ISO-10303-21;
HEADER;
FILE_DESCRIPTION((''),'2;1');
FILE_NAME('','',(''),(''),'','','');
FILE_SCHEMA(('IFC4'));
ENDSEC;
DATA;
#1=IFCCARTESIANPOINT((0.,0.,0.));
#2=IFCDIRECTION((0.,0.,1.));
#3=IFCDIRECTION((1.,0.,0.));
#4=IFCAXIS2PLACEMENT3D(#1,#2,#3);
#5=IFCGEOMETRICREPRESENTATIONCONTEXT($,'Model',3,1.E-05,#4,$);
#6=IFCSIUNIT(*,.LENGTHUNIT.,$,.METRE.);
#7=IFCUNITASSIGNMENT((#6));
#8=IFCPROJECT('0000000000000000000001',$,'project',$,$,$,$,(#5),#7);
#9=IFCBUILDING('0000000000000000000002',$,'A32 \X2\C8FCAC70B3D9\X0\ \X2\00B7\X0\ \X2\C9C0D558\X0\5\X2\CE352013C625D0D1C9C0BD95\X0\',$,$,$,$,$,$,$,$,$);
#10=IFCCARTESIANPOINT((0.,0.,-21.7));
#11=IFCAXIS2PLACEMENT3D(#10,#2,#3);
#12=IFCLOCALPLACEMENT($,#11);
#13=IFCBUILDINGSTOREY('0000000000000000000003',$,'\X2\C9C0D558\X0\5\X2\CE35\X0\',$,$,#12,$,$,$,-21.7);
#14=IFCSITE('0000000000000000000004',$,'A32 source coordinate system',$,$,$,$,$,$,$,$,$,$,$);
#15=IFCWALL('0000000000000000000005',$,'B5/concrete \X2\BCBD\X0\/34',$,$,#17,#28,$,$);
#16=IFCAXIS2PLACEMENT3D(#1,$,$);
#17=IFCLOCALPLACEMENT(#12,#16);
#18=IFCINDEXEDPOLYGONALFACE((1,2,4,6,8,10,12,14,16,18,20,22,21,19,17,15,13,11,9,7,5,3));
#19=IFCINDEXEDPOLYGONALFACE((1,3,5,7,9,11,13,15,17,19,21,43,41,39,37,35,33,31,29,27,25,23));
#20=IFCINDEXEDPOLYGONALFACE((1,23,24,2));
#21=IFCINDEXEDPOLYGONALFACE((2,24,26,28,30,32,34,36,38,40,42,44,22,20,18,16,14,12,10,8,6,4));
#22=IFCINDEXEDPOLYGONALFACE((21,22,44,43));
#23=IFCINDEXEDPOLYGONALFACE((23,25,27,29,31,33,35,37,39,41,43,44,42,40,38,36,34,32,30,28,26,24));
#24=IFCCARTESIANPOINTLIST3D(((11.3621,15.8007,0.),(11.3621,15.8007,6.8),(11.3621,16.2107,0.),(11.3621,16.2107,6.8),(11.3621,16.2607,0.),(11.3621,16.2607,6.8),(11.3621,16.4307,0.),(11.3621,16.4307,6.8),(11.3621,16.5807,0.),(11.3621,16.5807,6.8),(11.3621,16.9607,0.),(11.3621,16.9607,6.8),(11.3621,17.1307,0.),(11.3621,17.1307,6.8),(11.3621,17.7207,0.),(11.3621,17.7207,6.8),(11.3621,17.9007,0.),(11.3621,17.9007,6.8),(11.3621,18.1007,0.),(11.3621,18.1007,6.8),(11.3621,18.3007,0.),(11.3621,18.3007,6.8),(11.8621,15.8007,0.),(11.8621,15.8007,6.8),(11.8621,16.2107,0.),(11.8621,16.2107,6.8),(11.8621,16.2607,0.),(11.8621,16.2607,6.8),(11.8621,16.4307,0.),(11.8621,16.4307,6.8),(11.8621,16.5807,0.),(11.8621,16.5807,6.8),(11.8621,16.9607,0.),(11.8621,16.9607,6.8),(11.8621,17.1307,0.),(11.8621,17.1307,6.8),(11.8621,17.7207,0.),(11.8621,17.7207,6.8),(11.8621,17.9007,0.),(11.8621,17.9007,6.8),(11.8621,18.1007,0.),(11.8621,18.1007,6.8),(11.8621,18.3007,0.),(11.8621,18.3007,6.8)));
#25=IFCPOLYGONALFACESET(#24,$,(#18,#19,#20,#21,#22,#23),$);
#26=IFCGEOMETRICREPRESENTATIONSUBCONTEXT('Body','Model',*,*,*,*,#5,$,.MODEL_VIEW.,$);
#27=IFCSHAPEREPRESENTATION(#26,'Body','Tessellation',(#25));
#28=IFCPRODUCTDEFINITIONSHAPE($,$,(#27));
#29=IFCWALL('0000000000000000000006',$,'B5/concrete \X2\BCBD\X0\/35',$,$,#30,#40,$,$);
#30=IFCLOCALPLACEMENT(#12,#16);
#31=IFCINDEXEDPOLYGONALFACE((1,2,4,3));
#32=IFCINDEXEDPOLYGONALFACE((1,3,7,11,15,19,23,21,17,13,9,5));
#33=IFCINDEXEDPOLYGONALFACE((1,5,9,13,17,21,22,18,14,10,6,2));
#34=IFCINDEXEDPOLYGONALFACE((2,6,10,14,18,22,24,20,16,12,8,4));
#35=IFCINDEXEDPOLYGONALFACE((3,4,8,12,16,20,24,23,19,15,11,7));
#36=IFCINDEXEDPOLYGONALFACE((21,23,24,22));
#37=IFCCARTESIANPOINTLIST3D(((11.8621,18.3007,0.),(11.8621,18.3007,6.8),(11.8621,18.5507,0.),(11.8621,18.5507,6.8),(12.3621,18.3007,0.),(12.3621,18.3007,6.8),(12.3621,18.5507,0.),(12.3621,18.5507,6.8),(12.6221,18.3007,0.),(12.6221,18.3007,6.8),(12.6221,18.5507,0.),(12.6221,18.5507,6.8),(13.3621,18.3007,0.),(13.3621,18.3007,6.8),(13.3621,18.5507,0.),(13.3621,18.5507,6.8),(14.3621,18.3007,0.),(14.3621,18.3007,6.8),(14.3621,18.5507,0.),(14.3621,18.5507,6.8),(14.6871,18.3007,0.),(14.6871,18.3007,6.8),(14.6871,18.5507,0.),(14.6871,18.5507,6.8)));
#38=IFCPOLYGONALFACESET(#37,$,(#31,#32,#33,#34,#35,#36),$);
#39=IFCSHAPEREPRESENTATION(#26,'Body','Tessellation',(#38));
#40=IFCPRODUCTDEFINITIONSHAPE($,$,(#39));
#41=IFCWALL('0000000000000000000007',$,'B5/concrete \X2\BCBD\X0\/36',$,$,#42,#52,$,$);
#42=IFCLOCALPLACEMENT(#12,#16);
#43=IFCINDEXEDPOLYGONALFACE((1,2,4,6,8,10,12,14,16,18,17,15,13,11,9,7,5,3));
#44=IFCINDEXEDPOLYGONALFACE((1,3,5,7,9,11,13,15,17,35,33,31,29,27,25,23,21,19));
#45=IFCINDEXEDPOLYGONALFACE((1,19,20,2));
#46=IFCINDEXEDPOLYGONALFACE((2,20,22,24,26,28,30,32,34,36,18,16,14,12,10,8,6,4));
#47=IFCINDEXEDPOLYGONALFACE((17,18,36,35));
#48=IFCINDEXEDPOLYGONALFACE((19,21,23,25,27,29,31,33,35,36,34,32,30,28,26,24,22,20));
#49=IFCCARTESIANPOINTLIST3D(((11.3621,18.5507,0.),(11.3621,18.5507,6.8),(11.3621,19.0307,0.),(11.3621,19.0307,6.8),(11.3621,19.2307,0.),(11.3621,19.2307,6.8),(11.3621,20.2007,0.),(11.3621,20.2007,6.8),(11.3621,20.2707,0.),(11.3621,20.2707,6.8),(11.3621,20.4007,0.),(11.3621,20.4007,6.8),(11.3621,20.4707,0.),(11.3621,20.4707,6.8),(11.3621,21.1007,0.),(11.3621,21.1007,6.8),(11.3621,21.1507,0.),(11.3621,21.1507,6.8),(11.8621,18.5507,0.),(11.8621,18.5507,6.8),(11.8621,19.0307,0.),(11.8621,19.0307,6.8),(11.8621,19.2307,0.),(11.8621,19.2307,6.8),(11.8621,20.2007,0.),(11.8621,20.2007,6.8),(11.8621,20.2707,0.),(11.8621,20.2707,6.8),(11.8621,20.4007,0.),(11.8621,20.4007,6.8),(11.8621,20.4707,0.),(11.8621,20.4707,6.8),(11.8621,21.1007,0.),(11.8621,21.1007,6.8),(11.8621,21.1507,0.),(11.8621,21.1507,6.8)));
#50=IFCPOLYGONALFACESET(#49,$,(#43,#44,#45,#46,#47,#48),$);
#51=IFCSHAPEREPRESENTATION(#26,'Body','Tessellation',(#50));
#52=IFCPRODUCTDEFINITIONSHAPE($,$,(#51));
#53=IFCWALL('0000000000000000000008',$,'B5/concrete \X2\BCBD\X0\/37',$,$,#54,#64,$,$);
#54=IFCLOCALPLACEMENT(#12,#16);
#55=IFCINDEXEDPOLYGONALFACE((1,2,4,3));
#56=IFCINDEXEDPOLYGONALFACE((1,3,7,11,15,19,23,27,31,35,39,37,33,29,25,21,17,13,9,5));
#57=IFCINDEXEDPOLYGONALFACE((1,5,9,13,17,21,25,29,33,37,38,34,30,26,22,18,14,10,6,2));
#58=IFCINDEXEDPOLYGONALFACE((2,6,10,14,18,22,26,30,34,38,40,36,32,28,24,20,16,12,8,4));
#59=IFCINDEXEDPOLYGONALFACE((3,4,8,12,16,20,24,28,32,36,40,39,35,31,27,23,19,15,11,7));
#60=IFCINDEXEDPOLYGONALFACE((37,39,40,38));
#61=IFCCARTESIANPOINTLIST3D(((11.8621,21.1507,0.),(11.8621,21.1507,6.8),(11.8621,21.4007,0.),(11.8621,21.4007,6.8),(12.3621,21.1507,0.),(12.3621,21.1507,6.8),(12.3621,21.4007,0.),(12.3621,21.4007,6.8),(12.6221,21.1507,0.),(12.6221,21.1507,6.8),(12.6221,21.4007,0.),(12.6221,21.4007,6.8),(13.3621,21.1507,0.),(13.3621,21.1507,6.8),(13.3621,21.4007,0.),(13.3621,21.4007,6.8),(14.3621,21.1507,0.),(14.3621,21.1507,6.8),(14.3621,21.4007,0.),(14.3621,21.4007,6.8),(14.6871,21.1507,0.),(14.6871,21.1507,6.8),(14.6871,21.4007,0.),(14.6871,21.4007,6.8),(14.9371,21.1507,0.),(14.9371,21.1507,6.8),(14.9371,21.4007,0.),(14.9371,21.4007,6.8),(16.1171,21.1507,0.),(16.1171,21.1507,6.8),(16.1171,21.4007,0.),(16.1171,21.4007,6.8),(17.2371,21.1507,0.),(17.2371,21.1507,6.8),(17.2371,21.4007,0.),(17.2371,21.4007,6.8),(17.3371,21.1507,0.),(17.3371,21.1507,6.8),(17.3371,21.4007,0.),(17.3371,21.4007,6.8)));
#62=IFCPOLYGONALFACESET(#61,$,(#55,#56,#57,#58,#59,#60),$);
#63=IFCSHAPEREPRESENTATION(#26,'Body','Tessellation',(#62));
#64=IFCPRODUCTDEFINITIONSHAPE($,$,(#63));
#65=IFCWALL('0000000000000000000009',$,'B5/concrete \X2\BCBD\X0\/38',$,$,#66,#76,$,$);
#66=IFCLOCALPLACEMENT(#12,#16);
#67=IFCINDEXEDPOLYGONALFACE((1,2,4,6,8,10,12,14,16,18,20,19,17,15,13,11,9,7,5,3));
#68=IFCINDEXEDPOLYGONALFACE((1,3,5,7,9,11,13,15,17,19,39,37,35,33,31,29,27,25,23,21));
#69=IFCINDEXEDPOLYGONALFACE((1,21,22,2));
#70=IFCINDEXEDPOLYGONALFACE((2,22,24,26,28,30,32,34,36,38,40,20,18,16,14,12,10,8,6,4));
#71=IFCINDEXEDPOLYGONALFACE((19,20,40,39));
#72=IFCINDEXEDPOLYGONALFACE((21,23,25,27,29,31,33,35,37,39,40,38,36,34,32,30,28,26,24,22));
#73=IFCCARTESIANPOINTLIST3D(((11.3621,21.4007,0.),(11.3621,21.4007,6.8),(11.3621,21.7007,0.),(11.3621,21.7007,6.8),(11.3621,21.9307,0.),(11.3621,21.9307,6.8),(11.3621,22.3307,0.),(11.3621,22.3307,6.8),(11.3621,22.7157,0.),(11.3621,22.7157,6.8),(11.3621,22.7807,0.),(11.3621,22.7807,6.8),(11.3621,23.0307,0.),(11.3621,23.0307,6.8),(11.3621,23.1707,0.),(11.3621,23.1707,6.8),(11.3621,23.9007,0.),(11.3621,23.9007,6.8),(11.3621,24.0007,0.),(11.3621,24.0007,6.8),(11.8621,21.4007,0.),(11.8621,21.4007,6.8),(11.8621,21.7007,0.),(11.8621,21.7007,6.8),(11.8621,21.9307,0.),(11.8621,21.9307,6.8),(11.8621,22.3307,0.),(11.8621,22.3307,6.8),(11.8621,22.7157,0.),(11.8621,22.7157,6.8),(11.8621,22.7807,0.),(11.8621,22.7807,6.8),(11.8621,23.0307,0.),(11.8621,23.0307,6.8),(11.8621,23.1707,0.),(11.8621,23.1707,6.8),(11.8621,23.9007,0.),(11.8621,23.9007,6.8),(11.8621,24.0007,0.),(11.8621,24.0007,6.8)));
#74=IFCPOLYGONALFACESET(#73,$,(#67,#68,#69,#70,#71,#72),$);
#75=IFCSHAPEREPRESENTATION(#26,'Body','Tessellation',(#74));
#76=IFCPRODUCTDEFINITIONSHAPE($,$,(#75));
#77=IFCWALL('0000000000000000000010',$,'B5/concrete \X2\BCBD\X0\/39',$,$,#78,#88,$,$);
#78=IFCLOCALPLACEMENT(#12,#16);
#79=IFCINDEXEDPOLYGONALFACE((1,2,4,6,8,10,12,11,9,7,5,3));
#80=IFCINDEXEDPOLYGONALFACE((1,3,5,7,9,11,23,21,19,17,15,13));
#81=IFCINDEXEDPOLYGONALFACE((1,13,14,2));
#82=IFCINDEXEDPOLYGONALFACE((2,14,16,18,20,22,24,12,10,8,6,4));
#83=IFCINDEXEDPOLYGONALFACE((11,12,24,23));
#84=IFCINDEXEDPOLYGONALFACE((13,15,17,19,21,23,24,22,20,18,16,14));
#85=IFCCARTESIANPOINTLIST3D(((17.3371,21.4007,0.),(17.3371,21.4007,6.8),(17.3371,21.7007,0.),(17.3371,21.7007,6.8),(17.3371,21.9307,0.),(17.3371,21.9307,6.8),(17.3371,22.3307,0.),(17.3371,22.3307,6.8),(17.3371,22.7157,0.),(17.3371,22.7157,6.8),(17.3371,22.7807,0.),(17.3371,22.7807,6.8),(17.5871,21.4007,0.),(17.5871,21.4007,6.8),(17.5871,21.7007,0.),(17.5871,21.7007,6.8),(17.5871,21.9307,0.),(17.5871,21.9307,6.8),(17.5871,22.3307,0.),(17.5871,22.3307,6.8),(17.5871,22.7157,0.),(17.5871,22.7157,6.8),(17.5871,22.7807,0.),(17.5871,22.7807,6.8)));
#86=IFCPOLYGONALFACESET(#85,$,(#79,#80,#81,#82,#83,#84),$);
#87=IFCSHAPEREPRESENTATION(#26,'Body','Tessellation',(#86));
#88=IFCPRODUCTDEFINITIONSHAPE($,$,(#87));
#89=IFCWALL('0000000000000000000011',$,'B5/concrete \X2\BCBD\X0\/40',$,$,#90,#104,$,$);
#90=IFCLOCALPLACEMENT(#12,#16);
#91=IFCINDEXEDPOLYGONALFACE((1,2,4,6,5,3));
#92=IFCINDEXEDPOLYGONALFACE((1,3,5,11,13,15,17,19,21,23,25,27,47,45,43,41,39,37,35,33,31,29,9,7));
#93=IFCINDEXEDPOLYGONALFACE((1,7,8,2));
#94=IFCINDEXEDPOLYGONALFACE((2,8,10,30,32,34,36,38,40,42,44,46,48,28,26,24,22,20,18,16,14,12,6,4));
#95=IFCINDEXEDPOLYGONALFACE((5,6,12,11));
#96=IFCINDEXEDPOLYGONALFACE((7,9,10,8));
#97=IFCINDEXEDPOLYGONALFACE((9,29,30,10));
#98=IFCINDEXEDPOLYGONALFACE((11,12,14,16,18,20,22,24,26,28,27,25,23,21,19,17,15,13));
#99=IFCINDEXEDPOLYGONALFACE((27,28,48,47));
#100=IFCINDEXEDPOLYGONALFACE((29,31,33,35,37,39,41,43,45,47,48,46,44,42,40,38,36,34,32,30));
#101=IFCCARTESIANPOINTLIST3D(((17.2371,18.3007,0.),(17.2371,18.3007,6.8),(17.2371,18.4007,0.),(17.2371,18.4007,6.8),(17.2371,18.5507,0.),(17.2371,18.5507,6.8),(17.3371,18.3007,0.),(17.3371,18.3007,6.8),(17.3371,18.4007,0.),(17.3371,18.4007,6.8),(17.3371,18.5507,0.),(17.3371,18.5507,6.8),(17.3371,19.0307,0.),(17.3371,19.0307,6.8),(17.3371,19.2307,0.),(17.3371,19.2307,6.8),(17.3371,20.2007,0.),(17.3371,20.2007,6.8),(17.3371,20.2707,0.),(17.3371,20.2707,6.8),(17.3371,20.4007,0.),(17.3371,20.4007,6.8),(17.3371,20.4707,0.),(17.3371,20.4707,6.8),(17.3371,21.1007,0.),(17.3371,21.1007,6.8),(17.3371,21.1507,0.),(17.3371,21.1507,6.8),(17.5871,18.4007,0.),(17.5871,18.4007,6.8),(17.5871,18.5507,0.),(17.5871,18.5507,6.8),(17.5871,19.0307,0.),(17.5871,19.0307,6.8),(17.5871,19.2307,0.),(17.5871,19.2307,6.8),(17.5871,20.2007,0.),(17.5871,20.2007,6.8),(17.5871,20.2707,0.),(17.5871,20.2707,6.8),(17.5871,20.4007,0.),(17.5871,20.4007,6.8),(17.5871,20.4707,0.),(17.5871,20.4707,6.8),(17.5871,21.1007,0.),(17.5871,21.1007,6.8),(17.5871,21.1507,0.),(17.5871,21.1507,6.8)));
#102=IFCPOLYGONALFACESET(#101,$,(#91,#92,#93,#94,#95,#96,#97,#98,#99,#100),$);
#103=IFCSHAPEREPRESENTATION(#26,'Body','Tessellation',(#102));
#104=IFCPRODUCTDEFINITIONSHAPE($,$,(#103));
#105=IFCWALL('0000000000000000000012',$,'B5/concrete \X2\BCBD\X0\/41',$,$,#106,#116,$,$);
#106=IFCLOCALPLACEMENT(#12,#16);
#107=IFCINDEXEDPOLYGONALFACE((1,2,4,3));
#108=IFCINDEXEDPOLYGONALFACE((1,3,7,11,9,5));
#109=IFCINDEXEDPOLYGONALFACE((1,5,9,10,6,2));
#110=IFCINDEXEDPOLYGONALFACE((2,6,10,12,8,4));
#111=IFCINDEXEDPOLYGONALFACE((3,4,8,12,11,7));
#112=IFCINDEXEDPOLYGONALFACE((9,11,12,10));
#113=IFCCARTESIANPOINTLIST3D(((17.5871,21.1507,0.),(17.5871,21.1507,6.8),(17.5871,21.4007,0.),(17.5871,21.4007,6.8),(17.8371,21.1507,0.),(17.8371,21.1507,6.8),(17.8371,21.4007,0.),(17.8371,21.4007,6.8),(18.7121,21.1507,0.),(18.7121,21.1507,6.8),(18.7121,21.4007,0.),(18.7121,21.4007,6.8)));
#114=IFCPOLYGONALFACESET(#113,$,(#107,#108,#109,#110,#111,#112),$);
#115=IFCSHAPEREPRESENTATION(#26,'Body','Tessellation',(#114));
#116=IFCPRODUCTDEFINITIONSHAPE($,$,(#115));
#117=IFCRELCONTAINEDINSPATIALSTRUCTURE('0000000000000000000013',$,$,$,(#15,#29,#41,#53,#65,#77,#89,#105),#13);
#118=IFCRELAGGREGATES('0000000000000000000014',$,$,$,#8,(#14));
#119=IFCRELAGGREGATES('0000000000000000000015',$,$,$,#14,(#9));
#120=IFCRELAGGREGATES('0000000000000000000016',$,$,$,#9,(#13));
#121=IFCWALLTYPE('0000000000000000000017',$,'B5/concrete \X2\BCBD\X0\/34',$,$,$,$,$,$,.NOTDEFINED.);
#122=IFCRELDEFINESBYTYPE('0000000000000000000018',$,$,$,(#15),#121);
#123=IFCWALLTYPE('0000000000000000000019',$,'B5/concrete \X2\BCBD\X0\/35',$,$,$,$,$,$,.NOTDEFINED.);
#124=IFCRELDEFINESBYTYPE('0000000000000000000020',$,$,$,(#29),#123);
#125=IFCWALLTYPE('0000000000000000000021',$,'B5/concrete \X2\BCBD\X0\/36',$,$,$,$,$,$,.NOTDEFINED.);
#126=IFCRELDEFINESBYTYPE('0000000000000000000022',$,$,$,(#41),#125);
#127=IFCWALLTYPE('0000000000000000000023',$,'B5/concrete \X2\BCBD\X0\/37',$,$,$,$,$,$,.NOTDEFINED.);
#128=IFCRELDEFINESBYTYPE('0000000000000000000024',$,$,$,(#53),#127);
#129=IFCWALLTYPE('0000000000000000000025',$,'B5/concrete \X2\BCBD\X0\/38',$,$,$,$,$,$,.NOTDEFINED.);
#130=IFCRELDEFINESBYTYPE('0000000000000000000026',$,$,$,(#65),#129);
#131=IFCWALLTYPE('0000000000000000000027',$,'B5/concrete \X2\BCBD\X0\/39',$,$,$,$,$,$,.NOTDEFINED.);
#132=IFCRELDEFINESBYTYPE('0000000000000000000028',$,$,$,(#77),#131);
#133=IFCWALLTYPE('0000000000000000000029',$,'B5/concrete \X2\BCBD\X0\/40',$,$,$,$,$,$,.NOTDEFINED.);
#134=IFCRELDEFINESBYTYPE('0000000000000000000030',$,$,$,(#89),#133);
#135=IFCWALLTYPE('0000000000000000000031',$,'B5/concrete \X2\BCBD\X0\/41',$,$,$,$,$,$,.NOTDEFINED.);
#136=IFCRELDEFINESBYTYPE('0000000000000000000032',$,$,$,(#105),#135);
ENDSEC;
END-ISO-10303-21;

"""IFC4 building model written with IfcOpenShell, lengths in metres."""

from ifc_helpers import new_model, si_unit, frame, origin, origin_with_axes, place, context, subcontext, project, spatial, polyline, outline, extrude, source, transform, mapped, type_object, type_shapes, element, save


model = new_model("IFC4")

# Units and contexts
model_context = context("Model", 3, precision=1e-05, world=origin_with_axes())
body_context = subcontext(model_context, "Body", "Model", "MODEL_VIEW")
ifc_project = project(units=[si_unit("LENGTHUNIT", "METRE")], contexts=[model_context])

# Site, building, storey
site = spatial("IfcSite", under=ifc_project, Name="A32 source coordinate system")
building = spatial("IfcBuilding", under=site, Name="A32 주거동 · 지하5층–옥탑지붕")
storey_placement = place(None, frame((0.0, 0.0, -21.7), z_axis=(0.0, 0.0, 1.0), x_axis=(1.0, 0.0, 0.0)))
storey = spatial("IfcBuildingStorey", under=building, at=storey_placement, Name="지하5층", Elevation=-21.7)

# Walls
wall_type_1 = type_object("IfcWallType", Name="B5/concrete 벽/34", PredefinedType="NOTDEFINED")
shared_shape_1 = source(origin(), body_context, "Body", "SweptSolid", [
    extrude(outline(polyline([(11.3621, 16.2607), (11.3621, 16.4307), (11.3621, 16.5807), (11.3621, 16.9607), (11.3621, 17.1307), (11.3621, 17.7207), (11.3621, 17.9007), (11.3621, 18.1007), (11.3621, 18.3007), (11.8621, 18.3007), (11.8621, 18.1007), (11.8621, 17.9007), (11.8621, 17.7207), (11.8621, 17.1307), (11.8621, 16.9607), (11.8621, 16.5807), (11.8621, 16.4307), (11.8621, 16.2607), (11.8621, 16.2107), (11.8621, 15.8007), (11.3621, 15.8007), (11.3621, 16.2107), (11.3621, 16.2607)])), origin(), (0.0, 0.0, 1.0), 6.8),
])
type_shapes(wall_type_1, [shared_shape_1])
wall_1_placement = place(storey_placement, origin_with_axes())
element("IfcWall", 1, at=wall_1_placement, inside=storey, type_object=wall_type_1, Name="B5/concrete 벽/34", context=body_context, shape_type="MappedRepresentation", body=[
    mapped(shared_shape_1, transform((0.0, 0.0, 0.0), scale=1.0)),
])
wall_type_2 = type_object("IfcWallType", Name="B5/concrete 벽/35", PredefinedType="NOTDEFINED")
shared_shape_2 = source(origin(), body_context, "Body", "SweptSolid", [
    extrude(outline(polyline([(12.6221, 18.5507), (13.3621, 18.5507), (14.3621, 18.5507), (14.6871, 18.5507), (14.6871, 18.3007), (14.3621, 18.3007), (13.3621, 18.3007), (12.6221, 18.3007), (12.3621, 18.3007), (11.8621, 18.3007), (11.8621, 18.5507), (12.3621, 18.5507), (12.6221, 18.5507)])), origin(), (0.0, 0.0, 1.0), 6.8),
])
type_shapes(wall_type_2, [shared_shape_2])
wall_2_placement = place(storey_placement, origin_with_axes())
element("IfcWall", 2, at=wall_2_placement, inside=storey, type_object=wall_type_2, Name="B5/concrete 벽/35", context=body_context, shape_type="MappedRepresentation", body=[
    mapped(shared_shape_2, transform((0.0, 0.0, 0.0), scale=1.0)),
])
wall_type_3 = type_object("IfcWallType", Name="B5/concrete 벽/36", PredefinedType="NOTDEFINED")
shared_shape_3 = source(origin(), body_context, "Body", "SweptSolid", [
    extrude(outline(polyline([(11.3621, 19.2307), (11.3621, 20.2007), (11.3621, 20.2707), (11.3621, 20.4007), (11.3621, 20.4707), (11.3621, 21.1007), (11.3621, 21.1507), (11.8621, 21.1507), (11.8621, 21.1007), (11.8621, 20.4707), (11.8621, 20.4007), (11.8621, 20.2707), (11.8621, 20.2007), (11.8621, 19.2307), (11.8621, 19.0307), (11.8621, 18.5507), (11.3621, 18.5507), (11.3621, 19.0307), (11.3621, 19.2307)])), origin(), (0.0, 0.0, 1.0), 6.8),
])
type_shapes(wall_type_3, [shared_shape_3])
wall_3_placement = place(storey_placement, origin_with_axes())
element("IfcWall", 3, at=wall_3_placement, inside=storey, type_object=wall_type_3, Name="B5/concrete 벽/36", context=body_context, shape_type="MappedRepresentation", body=[
    mapped(shared_shape_3, transform((0.0, 0.0, 0.0), scale=1.0)),
])
wall_type_4 = type_object("IfcWallType", Name="B5/concrete 벽/37", PredefinedType="NOTDEFINED")
shared_shape_4 = source(origin(), body_context, "Body", "SweptSolid", [
    extrude(outline(polyline([(12.6221, 21.4007), (13.3621, 21.4007), (14.3621, 21.4007), (14.6871, 21.4007), (14.9371, 21.4007), (16.1171, 21.4007), (17.2371, 21.4007), (17.3371, 21.4007), (17.3371, 21.1507), (17.2371, 21.1507), (16.1171, 21.1507), (14.9371, 21.1507), (14.6871, 21.1507), (14.3621, 21.1507), (13.3621, 21.1507), (12.6221, 21.1507), (12.3621, 21.1507), (11.8621, 21.1507), (11.8621, 21.4007), (12.3621, 21.4007), (12.6221, 21.4007)])), origin(), (0.0, 0.0, 1.0), 6.8),
])
type_shapes(wall_type_4, [shared_shape_4])
wall_4_placement = place(storey_placement, origin_with_axes())
element("IfcWall", 4, at=wall_4_placement, inside=storey, type_object=wall_type_4, Name="B5/concrete 벽/37", context=body_context, shape_type="MappedRepresentation", body=[
    mapped(shared_shape_4, transform((0.0, 0.0, 0.0), scale=1.0)),
])
wall_type_5 = type_object("IfcWallType", Name="B5/concrete 벽/38", PredefinedType="NOTDEFINED")
shared_shape_5 = source(origin(), body_context, "Body", "SweptSolid", [
    extrude(outline(polyline([(11.3621, 21.9307), (11.3621, 22.3307), (11.3621, 22.7157), (11.3621, 22.7807), (11.3621, 23.0307), (11.3621, 23.1707), (11.3621, 23.9007), (11.3621, 24.0007), (11.8621, 24.0007), (11.8621, 23.9007), (11.8621, 23.1707), (11.8621, 23.0307), (11.8621, 22.7807), (11.8621, 22.7157), (11.8621, 22.3307), (11.8621, 21.9307), (11.8621, 21.7007), (11.8621, 21.4007), (11.3621, 21.4007), (11.3621, 21.7007), (11.3621, 21.9307)])), origin(), (0.0, 0.0, 1.0), 6.8),
])
type_shapes(wall_type_5, [shared_shape_5])
wall_5_placement = place(storey_placement, origin_with_axes())
element("IfcWall", 5, at=wall_5_placement, inside=storey, type_object=wall_type_5, Name="B5/concrete 벽/38", context=body_context, shape_type="MappedRepresentation", body=[
    mapped(shared_shape_5, transform((0.0, 0.0, 0.0), scale=1.0)),
])
wall_type_6 = type_object("IfcWallType", Name="B5/concrete 벽/39", PredefinedType="NOTDEFINED")
shared_shape_6 = source(origin(), body_context, "Body", "SweptSolid", [
    extrude(outline(polyline([(17.3371, 22.3307), (17.3371, 22.7157), (17.3371, 22.7807), (17.5871, 22.7807), (17.5871, 22.7157), (17.5871, 22.3307), (17.5871, 21.9307), (17.5871, 21.7007), (17.5871, 21.4007), (17.3371, 21.4007), (17.3371, 21.7007), (17.3371, 21.9307), (17.3371, 22.3307)])), origin(), (0.0, 0.0, 1.0), 6.8),
])
type_shapes(wall_type_6, [shared_shape_6])
wall_6_placement = place(storey_placement, origin_with_axes())
element("IfcWall", 6, at=wall_6_placement, inside=storey, type_object=wall_type_6, Name="B5/concrete 벽/39", context=body_context, shape_type="MappedRepresentation", body=[
    mapped(shared_shape_6, transform((0.0, 0.0, 0.0), scale=1.0)),
])
wall_type_7 = type_object("IfcWallType", Name="B5/concrete 벽/40", PredefinedType="NOTDEFINED")
shared_shape_7 = source(origin(), body_context, "Body", "SweptSolid", [
    extrude(outline(polyline([(17.5871, 20.4707), (17.5871, 20.4007), (17.5871, 20.2707), (17.5871, 20.2007), (17.5871, 19.2307), (17.5871, 19.0307), (17.5871, 18.5507), (17.5871, 18.4007), (17.3371, 18.4007), (17.3371, 18.3007), (17.2371, 18.3007), (17.2371, 18.4007), (17.2371, 18.5507), (17.3371, 18.5507), (17.3371, 19.0307), (17.3371, 19.2307), (17.3371, 20.2007), (17.3371, 20.2707), (17.3371, 20.4007), (17.3371, 20.4707), (17.3371, 21.1007), (17.3371, 21.1507), (17.5871, 21.1507), (17.5871, 21.1007), (17.5871, 20.4707)])), origin(), (0.0, 0.0, 1.0), 6.8),
])
type_shapes(wall_type_7, [shared_shape_7])
wall_7_placement = place(storey_placement, origin_with_axes())
element("IfcWall", 7, at=wall_7_placement, inside=storey, type_object=wall_type_7, Name="B5/concrete 벽/40", context=body_context, shape_type="MappedRepresentation", body=[
    mapped(shared_shape_7, transform((0.0, 0.0, 0.0), scale=1.0)),
])
wall_type_8 = type_object("IfcWallType", Name="B5/concrete 벽/41", PredefinedType="NOTDEFINED")
shared_shape_8 = source(origin(), body_context, "Body", "SweptSolid", [
    extrude(outline(polyline([(18.7121, 21.4007), (18.7121, 21.1507), (17.8371, 21.1507), (17.5871, 21.1507), (17.5871, 21.4007), (17.8371, 21.4007), (18.7121, 21.4007)])), origin(), (0.0, 0.0, 1.0), 6.8),
])
type_shapes(wall_type_8, [shared_shape_8])
wall_8_placement = place(storey_placement, origin_with_axes())
element("IfcWall", 8, at=wall_8_placement, inside=storey, type_object=wall_type_8, Name="B5/concrete 벽/41", context=body_context, shape_type="MappedRepresentation", body=[
    mapped(shared_shape_8, transform((0.0, 0.0, 0.0), scale=1.0)),
])

save(model, "model.ifc")
